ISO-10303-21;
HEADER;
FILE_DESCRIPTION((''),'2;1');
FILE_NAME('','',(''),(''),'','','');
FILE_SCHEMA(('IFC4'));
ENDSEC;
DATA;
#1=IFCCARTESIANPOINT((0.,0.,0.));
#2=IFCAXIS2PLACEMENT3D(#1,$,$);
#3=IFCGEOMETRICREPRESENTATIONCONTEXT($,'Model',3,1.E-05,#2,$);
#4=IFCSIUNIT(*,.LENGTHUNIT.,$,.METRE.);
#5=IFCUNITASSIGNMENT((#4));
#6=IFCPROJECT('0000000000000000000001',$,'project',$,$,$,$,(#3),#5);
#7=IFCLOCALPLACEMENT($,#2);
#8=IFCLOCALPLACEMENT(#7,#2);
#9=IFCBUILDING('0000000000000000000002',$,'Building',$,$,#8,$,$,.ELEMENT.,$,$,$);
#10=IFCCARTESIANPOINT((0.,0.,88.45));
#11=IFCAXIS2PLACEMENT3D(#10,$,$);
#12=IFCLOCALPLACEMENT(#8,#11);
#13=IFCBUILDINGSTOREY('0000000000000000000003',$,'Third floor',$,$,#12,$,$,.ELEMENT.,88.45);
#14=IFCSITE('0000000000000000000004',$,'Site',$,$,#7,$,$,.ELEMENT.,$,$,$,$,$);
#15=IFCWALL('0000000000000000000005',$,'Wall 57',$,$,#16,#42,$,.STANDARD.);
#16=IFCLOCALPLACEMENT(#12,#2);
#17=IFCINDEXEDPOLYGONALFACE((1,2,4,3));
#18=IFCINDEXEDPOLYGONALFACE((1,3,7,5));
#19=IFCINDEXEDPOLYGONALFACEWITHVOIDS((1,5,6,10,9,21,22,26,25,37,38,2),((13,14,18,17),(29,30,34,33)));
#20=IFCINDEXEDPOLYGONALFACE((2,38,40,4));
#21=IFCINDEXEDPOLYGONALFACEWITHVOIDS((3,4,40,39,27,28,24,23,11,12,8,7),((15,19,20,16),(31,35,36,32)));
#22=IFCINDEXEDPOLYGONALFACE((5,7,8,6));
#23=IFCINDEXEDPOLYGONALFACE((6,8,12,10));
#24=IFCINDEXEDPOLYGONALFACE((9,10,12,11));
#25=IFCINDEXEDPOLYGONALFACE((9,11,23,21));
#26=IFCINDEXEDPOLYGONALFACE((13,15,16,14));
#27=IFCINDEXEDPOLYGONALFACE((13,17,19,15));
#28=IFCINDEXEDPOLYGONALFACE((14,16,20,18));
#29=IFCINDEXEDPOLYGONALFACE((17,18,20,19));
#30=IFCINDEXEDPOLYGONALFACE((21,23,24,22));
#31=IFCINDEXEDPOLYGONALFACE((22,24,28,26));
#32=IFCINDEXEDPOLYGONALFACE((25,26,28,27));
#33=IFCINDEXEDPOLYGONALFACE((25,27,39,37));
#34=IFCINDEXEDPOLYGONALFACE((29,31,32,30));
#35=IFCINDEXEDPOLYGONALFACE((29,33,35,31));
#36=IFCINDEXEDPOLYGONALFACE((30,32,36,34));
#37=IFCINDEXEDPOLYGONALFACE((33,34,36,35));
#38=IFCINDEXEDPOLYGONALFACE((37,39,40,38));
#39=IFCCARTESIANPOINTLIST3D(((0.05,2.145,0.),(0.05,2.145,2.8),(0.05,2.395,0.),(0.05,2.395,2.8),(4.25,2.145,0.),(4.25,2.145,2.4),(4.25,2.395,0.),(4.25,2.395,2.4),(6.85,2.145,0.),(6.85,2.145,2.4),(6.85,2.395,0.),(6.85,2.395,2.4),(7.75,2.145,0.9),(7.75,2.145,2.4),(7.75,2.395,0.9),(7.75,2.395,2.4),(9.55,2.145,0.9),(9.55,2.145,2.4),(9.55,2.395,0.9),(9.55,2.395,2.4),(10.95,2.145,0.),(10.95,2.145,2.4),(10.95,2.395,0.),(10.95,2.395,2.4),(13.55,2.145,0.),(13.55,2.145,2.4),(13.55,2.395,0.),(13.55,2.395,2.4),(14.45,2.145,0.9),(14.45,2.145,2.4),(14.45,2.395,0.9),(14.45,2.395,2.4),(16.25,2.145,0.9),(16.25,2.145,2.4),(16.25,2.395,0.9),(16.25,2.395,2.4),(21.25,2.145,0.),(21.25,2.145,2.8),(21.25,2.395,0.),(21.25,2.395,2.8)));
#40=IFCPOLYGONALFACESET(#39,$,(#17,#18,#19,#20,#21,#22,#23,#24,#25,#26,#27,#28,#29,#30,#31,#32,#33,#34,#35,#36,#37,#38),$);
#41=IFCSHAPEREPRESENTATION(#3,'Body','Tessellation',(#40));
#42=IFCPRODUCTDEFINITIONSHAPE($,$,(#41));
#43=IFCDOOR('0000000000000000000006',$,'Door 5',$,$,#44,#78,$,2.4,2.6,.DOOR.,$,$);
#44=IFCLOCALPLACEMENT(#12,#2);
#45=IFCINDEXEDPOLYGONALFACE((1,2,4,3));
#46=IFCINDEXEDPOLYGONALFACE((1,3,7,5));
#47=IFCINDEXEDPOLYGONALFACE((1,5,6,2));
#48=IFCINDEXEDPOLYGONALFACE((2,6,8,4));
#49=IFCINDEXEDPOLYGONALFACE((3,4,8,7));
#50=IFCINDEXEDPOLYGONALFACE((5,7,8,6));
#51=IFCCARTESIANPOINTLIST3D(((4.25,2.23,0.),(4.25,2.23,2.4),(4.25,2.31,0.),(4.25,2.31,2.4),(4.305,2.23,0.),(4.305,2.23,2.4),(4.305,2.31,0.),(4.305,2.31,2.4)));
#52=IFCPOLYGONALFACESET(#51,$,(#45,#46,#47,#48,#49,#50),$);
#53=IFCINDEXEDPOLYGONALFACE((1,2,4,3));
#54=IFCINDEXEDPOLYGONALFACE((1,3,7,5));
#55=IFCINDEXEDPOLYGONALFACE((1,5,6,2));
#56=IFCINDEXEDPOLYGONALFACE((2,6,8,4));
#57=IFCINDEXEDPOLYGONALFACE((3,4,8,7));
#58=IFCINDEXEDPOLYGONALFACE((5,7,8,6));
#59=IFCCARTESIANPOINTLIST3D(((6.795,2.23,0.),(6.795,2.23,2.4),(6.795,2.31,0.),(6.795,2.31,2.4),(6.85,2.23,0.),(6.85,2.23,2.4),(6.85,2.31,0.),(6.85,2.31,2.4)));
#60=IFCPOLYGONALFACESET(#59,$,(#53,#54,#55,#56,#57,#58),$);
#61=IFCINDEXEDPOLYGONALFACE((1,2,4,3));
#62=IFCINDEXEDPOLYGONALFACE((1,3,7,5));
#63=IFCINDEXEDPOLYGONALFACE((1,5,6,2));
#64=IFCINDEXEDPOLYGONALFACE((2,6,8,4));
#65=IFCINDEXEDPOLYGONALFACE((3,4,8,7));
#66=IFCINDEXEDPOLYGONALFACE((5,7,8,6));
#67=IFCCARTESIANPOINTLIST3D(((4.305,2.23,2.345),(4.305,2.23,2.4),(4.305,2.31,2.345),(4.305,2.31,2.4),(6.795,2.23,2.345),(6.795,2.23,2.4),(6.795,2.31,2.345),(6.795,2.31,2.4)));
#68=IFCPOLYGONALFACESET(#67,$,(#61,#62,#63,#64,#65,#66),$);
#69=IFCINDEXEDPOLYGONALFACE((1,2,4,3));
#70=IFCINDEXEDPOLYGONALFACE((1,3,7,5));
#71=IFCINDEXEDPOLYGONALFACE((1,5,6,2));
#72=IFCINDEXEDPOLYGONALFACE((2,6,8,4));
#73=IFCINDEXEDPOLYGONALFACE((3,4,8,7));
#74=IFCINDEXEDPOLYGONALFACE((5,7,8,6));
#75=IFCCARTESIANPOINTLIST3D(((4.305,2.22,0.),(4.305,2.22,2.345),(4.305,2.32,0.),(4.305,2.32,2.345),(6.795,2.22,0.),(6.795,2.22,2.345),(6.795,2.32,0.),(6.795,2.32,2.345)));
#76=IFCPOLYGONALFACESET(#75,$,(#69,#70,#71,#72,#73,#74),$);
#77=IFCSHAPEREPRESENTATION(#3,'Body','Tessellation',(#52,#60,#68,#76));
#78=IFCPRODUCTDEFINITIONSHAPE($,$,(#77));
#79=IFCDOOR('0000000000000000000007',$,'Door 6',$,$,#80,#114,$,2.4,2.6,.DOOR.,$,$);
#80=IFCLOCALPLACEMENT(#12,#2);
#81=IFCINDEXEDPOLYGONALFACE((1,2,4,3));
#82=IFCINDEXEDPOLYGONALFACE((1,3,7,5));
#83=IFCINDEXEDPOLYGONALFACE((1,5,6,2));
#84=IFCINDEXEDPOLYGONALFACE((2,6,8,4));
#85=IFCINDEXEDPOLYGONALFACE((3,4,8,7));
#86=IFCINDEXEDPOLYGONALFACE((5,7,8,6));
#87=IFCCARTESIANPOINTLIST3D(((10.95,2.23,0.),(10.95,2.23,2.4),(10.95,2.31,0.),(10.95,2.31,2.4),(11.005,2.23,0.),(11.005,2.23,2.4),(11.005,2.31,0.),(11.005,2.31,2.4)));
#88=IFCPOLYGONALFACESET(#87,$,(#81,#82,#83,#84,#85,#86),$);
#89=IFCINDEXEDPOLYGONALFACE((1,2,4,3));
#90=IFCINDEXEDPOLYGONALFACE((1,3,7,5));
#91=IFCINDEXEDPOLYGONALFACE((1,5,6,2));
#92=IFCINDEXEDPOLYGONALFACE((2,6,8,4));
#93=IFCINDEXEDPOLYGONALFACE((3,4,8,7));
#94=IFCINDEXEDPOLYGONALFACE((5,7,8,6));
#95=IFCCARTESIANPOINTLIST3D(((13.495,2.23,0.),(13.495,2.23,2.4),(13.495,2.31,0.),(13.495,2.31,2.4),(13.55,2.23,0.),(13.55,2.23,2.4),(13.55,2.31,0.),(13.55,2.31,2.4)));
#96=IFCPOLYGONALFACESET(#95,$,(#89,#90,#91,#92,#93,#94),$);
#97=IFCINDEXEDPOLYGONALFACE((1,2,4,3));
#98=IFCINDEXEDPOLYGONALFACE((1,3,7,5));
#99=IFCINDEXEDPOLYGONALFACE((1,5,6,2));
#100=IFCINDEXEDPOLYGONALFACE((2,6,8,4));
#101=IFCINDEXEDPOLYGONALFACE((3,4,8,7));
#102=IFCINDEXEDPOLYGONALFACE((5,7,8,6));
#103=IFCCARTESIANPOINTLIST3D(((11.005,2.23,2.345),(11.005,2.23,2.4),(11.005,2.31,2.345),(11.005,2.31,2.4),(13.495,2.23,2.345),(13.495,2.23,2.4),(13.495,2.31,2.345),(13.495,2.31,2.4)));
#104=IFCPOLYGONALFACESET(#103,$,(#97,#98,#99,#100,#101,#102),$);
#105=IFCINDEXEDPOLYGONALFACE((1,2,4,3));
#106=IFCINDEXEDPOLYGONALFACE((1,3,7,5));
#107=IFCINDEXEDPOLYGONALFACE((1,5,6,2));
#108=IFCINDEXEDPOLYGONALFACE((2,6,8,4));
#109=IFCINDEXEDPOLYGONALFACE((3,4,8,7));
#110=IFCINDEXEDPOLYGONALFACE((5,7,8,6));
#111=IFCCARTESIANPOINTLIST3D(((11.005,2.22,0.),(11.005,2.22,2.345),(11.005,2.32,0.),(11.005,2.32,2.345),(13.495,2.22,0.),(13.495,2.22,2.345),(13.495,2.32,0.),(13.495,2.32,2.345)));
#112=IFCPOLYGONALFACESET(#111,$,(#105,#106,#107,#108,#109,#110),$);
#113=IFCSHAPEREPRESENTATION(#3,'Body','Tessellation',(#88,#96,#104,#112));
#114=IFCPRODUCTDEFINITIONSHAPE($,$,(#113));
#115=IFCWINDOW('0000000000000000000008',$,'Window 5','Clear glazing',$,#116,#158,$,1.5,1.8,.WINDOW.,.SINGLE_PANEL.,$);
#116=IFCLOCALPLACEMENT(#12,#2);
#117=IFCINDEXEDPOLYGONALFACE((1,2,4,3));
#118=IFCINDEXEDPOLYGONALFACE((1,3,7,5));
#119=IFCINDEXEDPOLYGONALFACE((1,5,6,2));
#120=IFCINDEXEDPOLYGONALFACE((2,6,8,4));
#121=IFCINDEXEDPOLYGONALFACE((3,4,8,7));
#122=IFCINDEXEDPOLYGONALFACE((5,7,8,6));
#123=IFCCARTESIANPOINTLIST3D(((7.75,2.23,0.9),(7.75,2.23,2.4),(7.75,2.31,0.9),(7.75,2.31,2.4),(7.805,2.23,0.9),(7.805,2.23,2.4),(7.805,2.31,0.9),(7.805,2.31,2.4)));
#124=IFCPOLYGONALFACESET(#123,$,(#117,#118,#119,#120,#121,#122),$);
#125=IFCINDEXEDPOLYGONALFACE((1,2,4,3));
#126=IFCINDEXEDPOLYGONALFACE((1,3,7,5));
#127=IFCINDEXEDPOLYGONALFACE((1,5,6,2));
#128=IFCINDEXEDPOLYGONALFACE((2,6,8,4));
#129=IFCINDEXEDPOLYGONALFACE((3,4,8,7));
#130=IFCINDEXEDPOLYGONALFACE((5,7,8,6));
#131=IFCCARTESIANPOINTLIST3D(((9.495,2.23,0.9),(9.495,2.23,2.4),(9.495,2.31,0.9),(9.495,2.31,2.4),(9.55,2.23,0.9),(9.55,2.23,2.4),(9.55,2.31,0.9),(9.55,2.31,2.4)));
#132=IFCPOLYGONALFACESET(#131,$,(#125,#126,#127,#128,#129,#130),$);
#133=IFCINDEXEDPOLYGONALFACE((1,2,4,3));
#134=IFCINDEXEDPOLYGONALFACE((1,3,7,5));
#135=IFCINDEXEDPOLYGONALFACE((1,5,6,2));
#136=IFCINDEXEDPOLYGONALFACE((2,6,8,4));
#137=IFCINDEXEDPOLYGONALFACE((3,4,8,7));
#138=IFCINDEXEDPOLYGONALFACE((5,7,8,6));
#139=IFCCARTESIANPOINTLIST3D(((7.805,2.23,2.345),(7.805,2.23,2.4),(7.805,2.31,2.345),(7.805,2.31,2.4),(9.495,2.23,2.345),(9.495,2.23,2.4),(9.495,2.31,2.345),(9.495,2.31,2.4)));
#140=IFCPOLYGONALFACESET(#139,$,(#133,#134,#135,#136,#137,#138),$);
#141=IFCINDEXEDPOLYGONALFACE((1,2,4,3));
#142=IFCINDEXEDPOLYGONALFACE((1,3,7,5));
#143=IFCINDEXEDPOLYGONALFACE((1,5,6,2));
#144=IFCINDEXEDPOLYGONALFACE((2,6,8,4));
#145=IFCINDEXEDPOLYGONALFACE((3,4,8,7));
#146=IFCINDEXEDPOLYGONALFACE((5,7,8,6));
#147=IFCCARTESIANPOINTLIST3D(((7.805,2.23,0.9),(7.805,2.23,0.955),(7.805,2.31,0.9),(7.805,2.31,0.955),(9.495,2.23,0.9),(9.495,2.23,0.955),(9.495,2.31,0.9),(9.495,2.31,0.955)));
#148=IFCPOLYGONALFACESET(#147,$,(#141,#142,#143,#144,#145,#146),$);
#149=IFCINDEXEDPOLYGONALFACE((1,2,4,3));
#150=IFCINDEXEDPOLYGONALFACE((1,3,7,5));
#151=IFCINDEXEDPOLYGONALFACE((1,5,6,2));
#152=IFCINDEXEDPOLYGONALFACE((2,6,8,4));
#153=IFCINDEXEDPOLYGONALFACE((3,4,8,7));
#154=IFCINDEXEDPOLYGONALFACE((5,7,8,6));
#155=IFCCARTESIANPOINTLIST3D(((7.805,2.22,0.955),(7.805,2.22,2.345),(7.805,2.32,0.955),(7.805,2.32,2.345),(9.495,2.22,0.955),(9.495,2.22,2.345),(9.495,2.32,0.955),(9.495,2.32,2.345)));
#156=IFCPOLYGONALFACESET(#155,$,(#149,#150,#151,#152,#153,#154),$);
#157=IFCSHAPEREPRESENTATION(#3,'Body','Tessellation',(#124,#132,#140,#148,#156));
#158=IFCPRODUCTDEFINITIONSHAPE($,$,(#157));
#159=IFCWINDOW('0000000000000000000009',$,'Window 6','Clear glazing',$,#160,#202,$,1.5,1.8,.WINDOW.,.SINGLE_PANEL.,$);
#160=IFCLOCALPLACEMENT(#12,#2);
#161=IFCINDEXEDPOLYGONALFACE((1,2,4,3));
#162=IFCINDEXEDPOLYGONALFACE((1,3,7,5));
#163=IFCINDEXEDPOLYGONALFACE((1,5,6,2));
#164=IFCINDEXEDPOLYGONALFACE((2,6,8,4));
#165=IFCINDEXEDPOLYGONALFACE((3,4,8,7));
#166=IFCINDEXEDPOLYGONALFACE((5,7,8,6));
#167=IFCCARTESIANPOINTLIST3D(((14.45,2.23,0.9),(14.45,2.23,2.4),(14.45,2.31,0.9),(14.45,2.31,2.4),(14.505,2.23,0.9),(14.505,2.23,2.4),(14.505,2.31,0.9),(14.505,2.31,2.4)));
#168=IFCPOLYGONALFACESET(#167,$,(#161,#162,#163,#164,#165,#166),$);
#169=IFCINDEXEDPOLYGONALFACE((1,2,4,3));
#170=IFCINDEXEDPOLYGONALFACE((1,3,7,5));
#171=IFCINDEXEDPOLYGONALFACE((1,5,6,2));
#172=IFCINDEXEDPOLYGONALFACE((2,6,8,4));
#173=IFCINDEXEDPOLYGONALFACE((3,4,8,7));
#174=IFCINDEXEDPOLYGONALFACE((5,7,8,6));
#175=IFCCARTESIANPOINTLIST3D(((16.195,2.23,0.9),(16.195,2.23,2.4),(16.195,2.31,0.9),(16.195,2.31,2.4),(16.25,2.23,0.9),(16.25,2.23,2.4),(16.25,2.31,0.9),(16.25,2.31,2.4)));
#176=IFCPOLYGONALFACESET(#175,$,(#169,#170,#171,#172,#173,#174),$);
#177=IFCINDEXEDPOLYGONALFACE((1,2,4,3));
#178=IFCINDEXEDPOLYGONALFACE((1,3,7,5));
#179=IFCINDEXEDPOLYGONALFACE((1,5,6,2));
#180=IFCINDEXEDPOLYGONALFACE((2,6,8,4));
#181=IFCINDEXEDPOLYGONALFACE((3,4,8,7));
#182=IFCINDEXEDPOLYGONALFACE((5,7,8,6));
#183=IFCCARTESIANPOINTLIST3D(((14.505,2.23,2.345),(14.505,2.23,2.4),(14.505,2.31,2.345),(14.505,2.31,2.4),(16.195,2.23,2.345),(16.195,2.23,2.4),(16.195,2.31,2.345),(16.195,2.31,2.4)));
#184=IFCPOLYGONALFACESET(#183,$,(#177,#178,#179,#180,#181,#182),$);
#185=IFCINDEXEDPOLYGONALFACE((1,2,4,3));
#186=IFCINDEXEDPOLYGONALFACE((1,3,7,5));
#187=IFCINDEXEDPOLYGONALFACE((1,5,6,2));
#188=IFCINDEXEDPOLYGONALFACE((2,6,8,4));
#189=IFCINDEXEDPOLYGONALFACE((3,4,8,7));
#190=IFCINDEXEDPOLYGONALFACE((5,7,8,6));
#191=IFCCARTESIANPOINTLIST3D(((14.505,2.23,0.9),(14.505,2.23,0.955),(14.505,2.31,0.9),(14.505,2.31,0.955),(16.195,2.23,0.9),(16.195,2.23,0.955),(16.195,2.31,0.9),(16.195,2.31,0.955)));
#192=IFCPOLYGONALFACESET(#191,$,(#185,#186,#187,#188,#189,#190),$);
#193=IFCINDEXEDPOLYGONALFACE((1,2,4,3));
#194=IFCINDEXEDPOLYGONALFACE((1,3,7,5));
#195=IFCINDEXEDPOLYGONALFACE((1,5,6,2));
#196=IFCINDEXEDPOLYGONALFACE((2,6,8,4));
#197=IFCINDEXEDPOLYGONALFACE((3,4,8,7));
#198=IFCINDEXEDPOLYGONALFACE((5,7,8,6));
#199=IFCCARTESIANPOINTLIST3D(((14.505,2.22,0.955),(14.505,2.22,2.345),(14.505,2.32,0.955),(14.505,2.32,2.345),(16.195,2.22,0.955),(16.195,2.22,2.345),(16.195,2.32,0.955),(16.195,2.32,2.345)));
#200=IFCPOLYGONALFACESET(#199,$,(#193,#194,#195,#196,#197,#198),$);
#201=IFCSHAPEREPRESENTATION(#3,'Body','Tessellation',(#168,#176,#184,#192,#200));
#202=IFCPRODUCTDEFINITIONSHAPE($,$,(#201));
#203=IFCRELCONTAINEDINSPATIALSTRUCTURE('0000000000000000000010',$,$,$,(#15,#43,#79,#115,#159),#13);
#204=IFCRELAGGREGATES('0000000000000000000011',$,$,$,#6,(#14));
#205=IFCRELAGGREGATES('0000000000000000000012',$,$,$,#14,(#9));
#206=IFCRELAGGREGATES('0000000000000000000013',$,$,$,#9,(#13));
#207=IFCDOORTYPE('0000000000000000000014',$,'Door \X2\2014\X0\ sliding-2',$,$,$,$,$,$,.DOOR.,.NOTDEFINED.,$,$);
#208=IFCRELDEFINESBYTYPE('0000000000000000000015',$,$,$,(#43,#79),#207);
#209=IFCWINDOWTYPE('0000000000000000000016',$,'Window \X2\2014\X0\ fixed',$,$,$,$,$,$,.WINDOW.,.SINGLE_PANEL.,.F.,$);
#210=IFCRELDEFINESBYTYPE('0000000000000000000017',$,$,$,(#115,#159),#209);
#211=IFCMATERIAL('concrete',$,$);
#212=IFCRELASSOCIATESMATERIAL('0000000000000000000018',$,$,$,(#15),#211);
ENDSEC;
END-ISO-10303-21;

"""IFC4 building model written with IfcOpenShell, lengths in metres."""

from ifc_helpers import new_model, si_unit, frame, frame_2d, origin, place, context, project, spatial, rectangle, extrude, material, type_object, element, fill, save


model = new_model("IFC4")

# Units and contexts
model_context = context("Model", 3, precision=1e-05, world=origin())
ifc_project = project(units=[si_unit("LENGTHUNIT", "METRE")], contexts=[model_context])

# Site, building, storey
site_placement = place(None, origin())
site = spatial("IfcSite", under=ifc_project, at=site_placement, Name="Site", CompositionType="ELEMENT")
building_placement = place(site_placement, origin())
building = spatial("IfcBuilding", under=site, at=building_placement, Name="Building", CompositionType="ELEMENT")
storey_placement = place(building_placement, frame((0.0, 0.0, 88.45)))
storey = spatial("IfcBuildingStorey", under=building, at=storey_placement, Name="Third floor", CompositionType="ELEMENT", Elevation=88.45)

# Shared definitions
ifc_material = material(Name="concrete")

# Wall, openings, doors, windows
wall_1_placement = place(storey_placement, frame((0.05, 2.27, 0.0), z_axis=(0.0, 0.0, 1.0), x_axis=(1.0, 0.0, 0.0)))
wall_1 = element("IfcWall", 1, at=wall_1_placement, inside=storey, material=ifc_material, Name="Wall 57", PredefinedType="STANDARD", context=model_context, shape_type="SweptSolid", body=[
    extrude(rectangle(XDim=21.2, YDim=0.25, at=frame_2d((10.6, 0.0))), origin(), (0.0, 0.0, 1.0), 2.8),
])
opening_1_placement = place(storey_placement, frame((4.25, 2.27, 0.0), z_axis=(0.0, 0.0, 1.0), x_axis=(1.0, 0.0, 0.0)))
opening_1 = element("IfcOpeningElement", 2, at=opening_1_placement, cuts=wall_1, PredefinedType="OPENING", context=model_context, shape_type="SweptSolid", body=[
    extrude(rectangle(XDim=2.6, YDim=0.31, at=frame_2d((1.3, 0.0))), origin(), (0.0, 0.0, 1.0), 2.4),
])
opening_2_placement = place(storey_placement, frame((7.75, 2.27, 0.9), z_axis=(0.0, 0.0, 1.0), x_axis=(1.0, 0.0, 0.0)))
opening_2 = element("IfcOpeningElement", 3, at=opening_2_placement, cuts=wall_1, PredefinedType="OPENING", context=model_context, shape_type="SweptSolid", body=[
    extrude(rectangle(XDim=1.8, YDim=0.31, at=frame_2d((0.9, 0.0))), origin(), (0.0, 0.0, 1.0), 1.5),
])
opening_3_placement = place(storey_placement, frame((10.95, 2.27, 0.0), z_axis=(0.0, 0.0, 1.0), x_axis=(1.0, 0.0, 0.0)))
opening_3 = element("IfcOpeningElement", 4, at=opening_3_placement, cuts=wall_1, PredefinedType="OPENING", context=model_context, shape_type="SweptSolid", body=[
    extrude(rectangle(XDim=2.6, YDim=0.31, at=frame_2d((1.3, 0.0))), origin(), (0.0, 0.0, 1.0), 2.4),
])
opening_4_placement = place(storey_placement, frame((14.45, 2.27, 0.9), z_axis=(0.0, 0.0, 1.0), x_axis=(1.0, 0.0, 0.0)))
opening_4 = element("IfcOpeningElement", 5, at=opening_4_placement, cuts=wall_1, PredefinedType="OPENING", context=model_context, shape_type="SweptSolid", body=[
    extrude(rectangle(XDim=1.8, YDim=0.31, at=frame_2d((0.9, 0.0))), origin(), (0.0, 0.0, 1.0), 1.5),
])
door_type = type_object("IfcDoorType", Name="Door — sliding-2", PredefinedType="DOOR")
door_1_placement = place(storey_placement, frame((4.25, 2.27, 0.0), z_axis=(0.0, 0.0, 1.0), x_axis=(1.0, 0.0, 0.0)))
door_1 = element("IfcDoor", 6, at=door_1_placement, inside=storey, type_object=door_type, Name="Door 5", OverallHeight=2.4, OverallWidth=2.6, PredefinedType="DOOR", context=model_context, shape_type="SweptSolid", body=[
    extrude(rectangle(XDim=0.055, YDim=0.08, at=frame_2d((0.0275, 0.0))), origin(), (0.0, 0.0, 1.0), 2.4),
    extrude(rectangle(XDim=0.055, YDim=0.08, at=frame_2d((2.5725, 0.0))), origin(), (0.0, 0.0, 1.0), 2.4),
    extrude(rectangle(XDim=2.49, YDim=0.08, at=frame_2d((1.3, 0.0))), frame((0.0, 0.0, 2.345)), (0.0, 0.0, 1.0), 0.055),
    extrude(rectangle(XDim=2.49, YDim=0.1, at=frame_2d((1.3, 0.0))), origin(), (0.0, 0.0, 1.0), 2.345),
])
fill(opening_1, door_1)
door_2_placement = place(storey_placement, frame((10.95, 2.27, 0.0), z_axis=(0.0, 0.0, 1.0), x_axis=(1.0, 0.0, 0.0)))
door_2 = element("IfcDoor", 7, at=door_2_placement, inside=storey, type_object=door_type, Name="Door 6", OverallHeight=2.4, OverallWidth=2.6, PredefinedType="DOOR", context=model_context, shape_type="SweptSolid", body=[
    extrude(rectangle(XDim=0.055, YDim=0.08, at=frame_2d((0.0275, 0.0))), origin(), (0.0, 0.0, 1.0), 2.4),
    extrude(rectangle(XDim=0.055, YDim=0.08, at=frame_2d((2.5725, 0.0))), origin(), (0.0, 0.0, 1.0), 2.4),
    extrude(rectangle(XDim=2.49, YDim=0.08, at=frame_2d((1.3, 0.0))), frame((0.0, 0.0, 2.345)), (0.0, 0.0, 1.0), 0.055),
    extrude(rectangle(XDim=2.49, YDim=0.1, at=frame_2d((1.3, 0.0))), origin(), (0.0, 0.0, 1.0), 2.345),
])
fill(opening_3, door_2)
window_type = type_object("IfcWindowType", Name="Window — fixed", ParameterTakesPrecedence=False, PartitioningType="SINGLE_PANEL", PredefinedType="WINDOW")
window_1_placement = place(storey_placement, frame((7.75, 2.27, 0.9), z_axis=(0.0, 0.0, 1.0), x_axis=(1.0, 0.0, 0.0)))
window_1 = element("IfcWindow", 8, at=window_1_placement, inside=storey, type_object=window_type, Name="Window 5", Description="Clear glazing", OverallHeight=1.5, OverallWidth=1.8, PartitioningType="SINGLE_PANEL", PredefinedType="WINDOW", context=model_context, shape_type="SweptSolid", body=[
    extrude(rectangle(XDim=0.055, YDim=0.08, at=frame_2d((0.0275, 0.0))), origin(), (0.0, 0.0, 1.0), 1.5),
    extrude(rectangle(XDim=0.055, YDim=0.08, at=frame_2d((1.7725, 0.0))), origin(), (0.0, 0.0, 1.0), 1.5),
    extrude(rectangle(XDim=1.69, YDim=0.08, at=frame_2d((0.9, 0.0))), frame((0.0, 0.0, 1.445)), (0.0, 0.0, 1.0), 0.055),
    extrude(rectangle(XDim=1.69, YDim=0.08, at=frame_2d((0.9, 0.0))), origin(), (0.0, 0.0, 1.0), 0.055),
    extrude(rectangle(XDim=1.69, YDim=0.1, at=frame_2d((0.9, 0.0))), frame((0.0, 0.0, 0.055)), (0.0, 0.0, 1.0), 1.39),
])
fill(opening_2, window_1)
window_2_placement = place(storey_placement, frame((14.45, 2.27, 0.9), z_axis=(0.0, 0.0, 1.0), x_axis=(1.0, 0.0, 0.0)))
window_2 = element("IfcWindow", 9, at=window_2_placement, inside=storey, type_object=window_type, Name="Window 6", Description="Clear glazing", OverallHeight=1.5, OverallWidth=1.8, PartitioningType="SINGLE_PANEL", PredefinedType="WINDOW", context=model_context, shape_type="SweptSolid", body=[
    extrude(rectangle(XDim=0.055, YDim=0.08, at=frame_2d((0.0275, 0.0))), origin(), (0.0, 0.0, 1.0), 1.5),
    extrude(rectangle(XDim=0.055, YDim=0.08, at=frame_2d((1.7725, 0.0))), origin(), (0.0, 0.0, 1.0), 1.5),
    extrude(rectangle(XDim=1.69, YDim=0.08, at=frame_2d((0.9, 0.0))), frame((0.0, 0.0, 1.445)), (0.0, 0.0, 1.0), 0.055),
    extrude(rectangle(XDim=1.69, YDim=0.08, at=frame_2d((0.9, 0.0))), origin(), (0.0, 0.0, 1.0), 0.055),
    extrude(rectangle(XDim=1.69, YDim=0.1, at=frame_2d((0.9, 0.0))), frame((0.0, 0.0, 0.055)), (0.0, 0.0, 1.0), 1.39),
])
fill(opening_4, window_2)

save(model, "model.ifc")
